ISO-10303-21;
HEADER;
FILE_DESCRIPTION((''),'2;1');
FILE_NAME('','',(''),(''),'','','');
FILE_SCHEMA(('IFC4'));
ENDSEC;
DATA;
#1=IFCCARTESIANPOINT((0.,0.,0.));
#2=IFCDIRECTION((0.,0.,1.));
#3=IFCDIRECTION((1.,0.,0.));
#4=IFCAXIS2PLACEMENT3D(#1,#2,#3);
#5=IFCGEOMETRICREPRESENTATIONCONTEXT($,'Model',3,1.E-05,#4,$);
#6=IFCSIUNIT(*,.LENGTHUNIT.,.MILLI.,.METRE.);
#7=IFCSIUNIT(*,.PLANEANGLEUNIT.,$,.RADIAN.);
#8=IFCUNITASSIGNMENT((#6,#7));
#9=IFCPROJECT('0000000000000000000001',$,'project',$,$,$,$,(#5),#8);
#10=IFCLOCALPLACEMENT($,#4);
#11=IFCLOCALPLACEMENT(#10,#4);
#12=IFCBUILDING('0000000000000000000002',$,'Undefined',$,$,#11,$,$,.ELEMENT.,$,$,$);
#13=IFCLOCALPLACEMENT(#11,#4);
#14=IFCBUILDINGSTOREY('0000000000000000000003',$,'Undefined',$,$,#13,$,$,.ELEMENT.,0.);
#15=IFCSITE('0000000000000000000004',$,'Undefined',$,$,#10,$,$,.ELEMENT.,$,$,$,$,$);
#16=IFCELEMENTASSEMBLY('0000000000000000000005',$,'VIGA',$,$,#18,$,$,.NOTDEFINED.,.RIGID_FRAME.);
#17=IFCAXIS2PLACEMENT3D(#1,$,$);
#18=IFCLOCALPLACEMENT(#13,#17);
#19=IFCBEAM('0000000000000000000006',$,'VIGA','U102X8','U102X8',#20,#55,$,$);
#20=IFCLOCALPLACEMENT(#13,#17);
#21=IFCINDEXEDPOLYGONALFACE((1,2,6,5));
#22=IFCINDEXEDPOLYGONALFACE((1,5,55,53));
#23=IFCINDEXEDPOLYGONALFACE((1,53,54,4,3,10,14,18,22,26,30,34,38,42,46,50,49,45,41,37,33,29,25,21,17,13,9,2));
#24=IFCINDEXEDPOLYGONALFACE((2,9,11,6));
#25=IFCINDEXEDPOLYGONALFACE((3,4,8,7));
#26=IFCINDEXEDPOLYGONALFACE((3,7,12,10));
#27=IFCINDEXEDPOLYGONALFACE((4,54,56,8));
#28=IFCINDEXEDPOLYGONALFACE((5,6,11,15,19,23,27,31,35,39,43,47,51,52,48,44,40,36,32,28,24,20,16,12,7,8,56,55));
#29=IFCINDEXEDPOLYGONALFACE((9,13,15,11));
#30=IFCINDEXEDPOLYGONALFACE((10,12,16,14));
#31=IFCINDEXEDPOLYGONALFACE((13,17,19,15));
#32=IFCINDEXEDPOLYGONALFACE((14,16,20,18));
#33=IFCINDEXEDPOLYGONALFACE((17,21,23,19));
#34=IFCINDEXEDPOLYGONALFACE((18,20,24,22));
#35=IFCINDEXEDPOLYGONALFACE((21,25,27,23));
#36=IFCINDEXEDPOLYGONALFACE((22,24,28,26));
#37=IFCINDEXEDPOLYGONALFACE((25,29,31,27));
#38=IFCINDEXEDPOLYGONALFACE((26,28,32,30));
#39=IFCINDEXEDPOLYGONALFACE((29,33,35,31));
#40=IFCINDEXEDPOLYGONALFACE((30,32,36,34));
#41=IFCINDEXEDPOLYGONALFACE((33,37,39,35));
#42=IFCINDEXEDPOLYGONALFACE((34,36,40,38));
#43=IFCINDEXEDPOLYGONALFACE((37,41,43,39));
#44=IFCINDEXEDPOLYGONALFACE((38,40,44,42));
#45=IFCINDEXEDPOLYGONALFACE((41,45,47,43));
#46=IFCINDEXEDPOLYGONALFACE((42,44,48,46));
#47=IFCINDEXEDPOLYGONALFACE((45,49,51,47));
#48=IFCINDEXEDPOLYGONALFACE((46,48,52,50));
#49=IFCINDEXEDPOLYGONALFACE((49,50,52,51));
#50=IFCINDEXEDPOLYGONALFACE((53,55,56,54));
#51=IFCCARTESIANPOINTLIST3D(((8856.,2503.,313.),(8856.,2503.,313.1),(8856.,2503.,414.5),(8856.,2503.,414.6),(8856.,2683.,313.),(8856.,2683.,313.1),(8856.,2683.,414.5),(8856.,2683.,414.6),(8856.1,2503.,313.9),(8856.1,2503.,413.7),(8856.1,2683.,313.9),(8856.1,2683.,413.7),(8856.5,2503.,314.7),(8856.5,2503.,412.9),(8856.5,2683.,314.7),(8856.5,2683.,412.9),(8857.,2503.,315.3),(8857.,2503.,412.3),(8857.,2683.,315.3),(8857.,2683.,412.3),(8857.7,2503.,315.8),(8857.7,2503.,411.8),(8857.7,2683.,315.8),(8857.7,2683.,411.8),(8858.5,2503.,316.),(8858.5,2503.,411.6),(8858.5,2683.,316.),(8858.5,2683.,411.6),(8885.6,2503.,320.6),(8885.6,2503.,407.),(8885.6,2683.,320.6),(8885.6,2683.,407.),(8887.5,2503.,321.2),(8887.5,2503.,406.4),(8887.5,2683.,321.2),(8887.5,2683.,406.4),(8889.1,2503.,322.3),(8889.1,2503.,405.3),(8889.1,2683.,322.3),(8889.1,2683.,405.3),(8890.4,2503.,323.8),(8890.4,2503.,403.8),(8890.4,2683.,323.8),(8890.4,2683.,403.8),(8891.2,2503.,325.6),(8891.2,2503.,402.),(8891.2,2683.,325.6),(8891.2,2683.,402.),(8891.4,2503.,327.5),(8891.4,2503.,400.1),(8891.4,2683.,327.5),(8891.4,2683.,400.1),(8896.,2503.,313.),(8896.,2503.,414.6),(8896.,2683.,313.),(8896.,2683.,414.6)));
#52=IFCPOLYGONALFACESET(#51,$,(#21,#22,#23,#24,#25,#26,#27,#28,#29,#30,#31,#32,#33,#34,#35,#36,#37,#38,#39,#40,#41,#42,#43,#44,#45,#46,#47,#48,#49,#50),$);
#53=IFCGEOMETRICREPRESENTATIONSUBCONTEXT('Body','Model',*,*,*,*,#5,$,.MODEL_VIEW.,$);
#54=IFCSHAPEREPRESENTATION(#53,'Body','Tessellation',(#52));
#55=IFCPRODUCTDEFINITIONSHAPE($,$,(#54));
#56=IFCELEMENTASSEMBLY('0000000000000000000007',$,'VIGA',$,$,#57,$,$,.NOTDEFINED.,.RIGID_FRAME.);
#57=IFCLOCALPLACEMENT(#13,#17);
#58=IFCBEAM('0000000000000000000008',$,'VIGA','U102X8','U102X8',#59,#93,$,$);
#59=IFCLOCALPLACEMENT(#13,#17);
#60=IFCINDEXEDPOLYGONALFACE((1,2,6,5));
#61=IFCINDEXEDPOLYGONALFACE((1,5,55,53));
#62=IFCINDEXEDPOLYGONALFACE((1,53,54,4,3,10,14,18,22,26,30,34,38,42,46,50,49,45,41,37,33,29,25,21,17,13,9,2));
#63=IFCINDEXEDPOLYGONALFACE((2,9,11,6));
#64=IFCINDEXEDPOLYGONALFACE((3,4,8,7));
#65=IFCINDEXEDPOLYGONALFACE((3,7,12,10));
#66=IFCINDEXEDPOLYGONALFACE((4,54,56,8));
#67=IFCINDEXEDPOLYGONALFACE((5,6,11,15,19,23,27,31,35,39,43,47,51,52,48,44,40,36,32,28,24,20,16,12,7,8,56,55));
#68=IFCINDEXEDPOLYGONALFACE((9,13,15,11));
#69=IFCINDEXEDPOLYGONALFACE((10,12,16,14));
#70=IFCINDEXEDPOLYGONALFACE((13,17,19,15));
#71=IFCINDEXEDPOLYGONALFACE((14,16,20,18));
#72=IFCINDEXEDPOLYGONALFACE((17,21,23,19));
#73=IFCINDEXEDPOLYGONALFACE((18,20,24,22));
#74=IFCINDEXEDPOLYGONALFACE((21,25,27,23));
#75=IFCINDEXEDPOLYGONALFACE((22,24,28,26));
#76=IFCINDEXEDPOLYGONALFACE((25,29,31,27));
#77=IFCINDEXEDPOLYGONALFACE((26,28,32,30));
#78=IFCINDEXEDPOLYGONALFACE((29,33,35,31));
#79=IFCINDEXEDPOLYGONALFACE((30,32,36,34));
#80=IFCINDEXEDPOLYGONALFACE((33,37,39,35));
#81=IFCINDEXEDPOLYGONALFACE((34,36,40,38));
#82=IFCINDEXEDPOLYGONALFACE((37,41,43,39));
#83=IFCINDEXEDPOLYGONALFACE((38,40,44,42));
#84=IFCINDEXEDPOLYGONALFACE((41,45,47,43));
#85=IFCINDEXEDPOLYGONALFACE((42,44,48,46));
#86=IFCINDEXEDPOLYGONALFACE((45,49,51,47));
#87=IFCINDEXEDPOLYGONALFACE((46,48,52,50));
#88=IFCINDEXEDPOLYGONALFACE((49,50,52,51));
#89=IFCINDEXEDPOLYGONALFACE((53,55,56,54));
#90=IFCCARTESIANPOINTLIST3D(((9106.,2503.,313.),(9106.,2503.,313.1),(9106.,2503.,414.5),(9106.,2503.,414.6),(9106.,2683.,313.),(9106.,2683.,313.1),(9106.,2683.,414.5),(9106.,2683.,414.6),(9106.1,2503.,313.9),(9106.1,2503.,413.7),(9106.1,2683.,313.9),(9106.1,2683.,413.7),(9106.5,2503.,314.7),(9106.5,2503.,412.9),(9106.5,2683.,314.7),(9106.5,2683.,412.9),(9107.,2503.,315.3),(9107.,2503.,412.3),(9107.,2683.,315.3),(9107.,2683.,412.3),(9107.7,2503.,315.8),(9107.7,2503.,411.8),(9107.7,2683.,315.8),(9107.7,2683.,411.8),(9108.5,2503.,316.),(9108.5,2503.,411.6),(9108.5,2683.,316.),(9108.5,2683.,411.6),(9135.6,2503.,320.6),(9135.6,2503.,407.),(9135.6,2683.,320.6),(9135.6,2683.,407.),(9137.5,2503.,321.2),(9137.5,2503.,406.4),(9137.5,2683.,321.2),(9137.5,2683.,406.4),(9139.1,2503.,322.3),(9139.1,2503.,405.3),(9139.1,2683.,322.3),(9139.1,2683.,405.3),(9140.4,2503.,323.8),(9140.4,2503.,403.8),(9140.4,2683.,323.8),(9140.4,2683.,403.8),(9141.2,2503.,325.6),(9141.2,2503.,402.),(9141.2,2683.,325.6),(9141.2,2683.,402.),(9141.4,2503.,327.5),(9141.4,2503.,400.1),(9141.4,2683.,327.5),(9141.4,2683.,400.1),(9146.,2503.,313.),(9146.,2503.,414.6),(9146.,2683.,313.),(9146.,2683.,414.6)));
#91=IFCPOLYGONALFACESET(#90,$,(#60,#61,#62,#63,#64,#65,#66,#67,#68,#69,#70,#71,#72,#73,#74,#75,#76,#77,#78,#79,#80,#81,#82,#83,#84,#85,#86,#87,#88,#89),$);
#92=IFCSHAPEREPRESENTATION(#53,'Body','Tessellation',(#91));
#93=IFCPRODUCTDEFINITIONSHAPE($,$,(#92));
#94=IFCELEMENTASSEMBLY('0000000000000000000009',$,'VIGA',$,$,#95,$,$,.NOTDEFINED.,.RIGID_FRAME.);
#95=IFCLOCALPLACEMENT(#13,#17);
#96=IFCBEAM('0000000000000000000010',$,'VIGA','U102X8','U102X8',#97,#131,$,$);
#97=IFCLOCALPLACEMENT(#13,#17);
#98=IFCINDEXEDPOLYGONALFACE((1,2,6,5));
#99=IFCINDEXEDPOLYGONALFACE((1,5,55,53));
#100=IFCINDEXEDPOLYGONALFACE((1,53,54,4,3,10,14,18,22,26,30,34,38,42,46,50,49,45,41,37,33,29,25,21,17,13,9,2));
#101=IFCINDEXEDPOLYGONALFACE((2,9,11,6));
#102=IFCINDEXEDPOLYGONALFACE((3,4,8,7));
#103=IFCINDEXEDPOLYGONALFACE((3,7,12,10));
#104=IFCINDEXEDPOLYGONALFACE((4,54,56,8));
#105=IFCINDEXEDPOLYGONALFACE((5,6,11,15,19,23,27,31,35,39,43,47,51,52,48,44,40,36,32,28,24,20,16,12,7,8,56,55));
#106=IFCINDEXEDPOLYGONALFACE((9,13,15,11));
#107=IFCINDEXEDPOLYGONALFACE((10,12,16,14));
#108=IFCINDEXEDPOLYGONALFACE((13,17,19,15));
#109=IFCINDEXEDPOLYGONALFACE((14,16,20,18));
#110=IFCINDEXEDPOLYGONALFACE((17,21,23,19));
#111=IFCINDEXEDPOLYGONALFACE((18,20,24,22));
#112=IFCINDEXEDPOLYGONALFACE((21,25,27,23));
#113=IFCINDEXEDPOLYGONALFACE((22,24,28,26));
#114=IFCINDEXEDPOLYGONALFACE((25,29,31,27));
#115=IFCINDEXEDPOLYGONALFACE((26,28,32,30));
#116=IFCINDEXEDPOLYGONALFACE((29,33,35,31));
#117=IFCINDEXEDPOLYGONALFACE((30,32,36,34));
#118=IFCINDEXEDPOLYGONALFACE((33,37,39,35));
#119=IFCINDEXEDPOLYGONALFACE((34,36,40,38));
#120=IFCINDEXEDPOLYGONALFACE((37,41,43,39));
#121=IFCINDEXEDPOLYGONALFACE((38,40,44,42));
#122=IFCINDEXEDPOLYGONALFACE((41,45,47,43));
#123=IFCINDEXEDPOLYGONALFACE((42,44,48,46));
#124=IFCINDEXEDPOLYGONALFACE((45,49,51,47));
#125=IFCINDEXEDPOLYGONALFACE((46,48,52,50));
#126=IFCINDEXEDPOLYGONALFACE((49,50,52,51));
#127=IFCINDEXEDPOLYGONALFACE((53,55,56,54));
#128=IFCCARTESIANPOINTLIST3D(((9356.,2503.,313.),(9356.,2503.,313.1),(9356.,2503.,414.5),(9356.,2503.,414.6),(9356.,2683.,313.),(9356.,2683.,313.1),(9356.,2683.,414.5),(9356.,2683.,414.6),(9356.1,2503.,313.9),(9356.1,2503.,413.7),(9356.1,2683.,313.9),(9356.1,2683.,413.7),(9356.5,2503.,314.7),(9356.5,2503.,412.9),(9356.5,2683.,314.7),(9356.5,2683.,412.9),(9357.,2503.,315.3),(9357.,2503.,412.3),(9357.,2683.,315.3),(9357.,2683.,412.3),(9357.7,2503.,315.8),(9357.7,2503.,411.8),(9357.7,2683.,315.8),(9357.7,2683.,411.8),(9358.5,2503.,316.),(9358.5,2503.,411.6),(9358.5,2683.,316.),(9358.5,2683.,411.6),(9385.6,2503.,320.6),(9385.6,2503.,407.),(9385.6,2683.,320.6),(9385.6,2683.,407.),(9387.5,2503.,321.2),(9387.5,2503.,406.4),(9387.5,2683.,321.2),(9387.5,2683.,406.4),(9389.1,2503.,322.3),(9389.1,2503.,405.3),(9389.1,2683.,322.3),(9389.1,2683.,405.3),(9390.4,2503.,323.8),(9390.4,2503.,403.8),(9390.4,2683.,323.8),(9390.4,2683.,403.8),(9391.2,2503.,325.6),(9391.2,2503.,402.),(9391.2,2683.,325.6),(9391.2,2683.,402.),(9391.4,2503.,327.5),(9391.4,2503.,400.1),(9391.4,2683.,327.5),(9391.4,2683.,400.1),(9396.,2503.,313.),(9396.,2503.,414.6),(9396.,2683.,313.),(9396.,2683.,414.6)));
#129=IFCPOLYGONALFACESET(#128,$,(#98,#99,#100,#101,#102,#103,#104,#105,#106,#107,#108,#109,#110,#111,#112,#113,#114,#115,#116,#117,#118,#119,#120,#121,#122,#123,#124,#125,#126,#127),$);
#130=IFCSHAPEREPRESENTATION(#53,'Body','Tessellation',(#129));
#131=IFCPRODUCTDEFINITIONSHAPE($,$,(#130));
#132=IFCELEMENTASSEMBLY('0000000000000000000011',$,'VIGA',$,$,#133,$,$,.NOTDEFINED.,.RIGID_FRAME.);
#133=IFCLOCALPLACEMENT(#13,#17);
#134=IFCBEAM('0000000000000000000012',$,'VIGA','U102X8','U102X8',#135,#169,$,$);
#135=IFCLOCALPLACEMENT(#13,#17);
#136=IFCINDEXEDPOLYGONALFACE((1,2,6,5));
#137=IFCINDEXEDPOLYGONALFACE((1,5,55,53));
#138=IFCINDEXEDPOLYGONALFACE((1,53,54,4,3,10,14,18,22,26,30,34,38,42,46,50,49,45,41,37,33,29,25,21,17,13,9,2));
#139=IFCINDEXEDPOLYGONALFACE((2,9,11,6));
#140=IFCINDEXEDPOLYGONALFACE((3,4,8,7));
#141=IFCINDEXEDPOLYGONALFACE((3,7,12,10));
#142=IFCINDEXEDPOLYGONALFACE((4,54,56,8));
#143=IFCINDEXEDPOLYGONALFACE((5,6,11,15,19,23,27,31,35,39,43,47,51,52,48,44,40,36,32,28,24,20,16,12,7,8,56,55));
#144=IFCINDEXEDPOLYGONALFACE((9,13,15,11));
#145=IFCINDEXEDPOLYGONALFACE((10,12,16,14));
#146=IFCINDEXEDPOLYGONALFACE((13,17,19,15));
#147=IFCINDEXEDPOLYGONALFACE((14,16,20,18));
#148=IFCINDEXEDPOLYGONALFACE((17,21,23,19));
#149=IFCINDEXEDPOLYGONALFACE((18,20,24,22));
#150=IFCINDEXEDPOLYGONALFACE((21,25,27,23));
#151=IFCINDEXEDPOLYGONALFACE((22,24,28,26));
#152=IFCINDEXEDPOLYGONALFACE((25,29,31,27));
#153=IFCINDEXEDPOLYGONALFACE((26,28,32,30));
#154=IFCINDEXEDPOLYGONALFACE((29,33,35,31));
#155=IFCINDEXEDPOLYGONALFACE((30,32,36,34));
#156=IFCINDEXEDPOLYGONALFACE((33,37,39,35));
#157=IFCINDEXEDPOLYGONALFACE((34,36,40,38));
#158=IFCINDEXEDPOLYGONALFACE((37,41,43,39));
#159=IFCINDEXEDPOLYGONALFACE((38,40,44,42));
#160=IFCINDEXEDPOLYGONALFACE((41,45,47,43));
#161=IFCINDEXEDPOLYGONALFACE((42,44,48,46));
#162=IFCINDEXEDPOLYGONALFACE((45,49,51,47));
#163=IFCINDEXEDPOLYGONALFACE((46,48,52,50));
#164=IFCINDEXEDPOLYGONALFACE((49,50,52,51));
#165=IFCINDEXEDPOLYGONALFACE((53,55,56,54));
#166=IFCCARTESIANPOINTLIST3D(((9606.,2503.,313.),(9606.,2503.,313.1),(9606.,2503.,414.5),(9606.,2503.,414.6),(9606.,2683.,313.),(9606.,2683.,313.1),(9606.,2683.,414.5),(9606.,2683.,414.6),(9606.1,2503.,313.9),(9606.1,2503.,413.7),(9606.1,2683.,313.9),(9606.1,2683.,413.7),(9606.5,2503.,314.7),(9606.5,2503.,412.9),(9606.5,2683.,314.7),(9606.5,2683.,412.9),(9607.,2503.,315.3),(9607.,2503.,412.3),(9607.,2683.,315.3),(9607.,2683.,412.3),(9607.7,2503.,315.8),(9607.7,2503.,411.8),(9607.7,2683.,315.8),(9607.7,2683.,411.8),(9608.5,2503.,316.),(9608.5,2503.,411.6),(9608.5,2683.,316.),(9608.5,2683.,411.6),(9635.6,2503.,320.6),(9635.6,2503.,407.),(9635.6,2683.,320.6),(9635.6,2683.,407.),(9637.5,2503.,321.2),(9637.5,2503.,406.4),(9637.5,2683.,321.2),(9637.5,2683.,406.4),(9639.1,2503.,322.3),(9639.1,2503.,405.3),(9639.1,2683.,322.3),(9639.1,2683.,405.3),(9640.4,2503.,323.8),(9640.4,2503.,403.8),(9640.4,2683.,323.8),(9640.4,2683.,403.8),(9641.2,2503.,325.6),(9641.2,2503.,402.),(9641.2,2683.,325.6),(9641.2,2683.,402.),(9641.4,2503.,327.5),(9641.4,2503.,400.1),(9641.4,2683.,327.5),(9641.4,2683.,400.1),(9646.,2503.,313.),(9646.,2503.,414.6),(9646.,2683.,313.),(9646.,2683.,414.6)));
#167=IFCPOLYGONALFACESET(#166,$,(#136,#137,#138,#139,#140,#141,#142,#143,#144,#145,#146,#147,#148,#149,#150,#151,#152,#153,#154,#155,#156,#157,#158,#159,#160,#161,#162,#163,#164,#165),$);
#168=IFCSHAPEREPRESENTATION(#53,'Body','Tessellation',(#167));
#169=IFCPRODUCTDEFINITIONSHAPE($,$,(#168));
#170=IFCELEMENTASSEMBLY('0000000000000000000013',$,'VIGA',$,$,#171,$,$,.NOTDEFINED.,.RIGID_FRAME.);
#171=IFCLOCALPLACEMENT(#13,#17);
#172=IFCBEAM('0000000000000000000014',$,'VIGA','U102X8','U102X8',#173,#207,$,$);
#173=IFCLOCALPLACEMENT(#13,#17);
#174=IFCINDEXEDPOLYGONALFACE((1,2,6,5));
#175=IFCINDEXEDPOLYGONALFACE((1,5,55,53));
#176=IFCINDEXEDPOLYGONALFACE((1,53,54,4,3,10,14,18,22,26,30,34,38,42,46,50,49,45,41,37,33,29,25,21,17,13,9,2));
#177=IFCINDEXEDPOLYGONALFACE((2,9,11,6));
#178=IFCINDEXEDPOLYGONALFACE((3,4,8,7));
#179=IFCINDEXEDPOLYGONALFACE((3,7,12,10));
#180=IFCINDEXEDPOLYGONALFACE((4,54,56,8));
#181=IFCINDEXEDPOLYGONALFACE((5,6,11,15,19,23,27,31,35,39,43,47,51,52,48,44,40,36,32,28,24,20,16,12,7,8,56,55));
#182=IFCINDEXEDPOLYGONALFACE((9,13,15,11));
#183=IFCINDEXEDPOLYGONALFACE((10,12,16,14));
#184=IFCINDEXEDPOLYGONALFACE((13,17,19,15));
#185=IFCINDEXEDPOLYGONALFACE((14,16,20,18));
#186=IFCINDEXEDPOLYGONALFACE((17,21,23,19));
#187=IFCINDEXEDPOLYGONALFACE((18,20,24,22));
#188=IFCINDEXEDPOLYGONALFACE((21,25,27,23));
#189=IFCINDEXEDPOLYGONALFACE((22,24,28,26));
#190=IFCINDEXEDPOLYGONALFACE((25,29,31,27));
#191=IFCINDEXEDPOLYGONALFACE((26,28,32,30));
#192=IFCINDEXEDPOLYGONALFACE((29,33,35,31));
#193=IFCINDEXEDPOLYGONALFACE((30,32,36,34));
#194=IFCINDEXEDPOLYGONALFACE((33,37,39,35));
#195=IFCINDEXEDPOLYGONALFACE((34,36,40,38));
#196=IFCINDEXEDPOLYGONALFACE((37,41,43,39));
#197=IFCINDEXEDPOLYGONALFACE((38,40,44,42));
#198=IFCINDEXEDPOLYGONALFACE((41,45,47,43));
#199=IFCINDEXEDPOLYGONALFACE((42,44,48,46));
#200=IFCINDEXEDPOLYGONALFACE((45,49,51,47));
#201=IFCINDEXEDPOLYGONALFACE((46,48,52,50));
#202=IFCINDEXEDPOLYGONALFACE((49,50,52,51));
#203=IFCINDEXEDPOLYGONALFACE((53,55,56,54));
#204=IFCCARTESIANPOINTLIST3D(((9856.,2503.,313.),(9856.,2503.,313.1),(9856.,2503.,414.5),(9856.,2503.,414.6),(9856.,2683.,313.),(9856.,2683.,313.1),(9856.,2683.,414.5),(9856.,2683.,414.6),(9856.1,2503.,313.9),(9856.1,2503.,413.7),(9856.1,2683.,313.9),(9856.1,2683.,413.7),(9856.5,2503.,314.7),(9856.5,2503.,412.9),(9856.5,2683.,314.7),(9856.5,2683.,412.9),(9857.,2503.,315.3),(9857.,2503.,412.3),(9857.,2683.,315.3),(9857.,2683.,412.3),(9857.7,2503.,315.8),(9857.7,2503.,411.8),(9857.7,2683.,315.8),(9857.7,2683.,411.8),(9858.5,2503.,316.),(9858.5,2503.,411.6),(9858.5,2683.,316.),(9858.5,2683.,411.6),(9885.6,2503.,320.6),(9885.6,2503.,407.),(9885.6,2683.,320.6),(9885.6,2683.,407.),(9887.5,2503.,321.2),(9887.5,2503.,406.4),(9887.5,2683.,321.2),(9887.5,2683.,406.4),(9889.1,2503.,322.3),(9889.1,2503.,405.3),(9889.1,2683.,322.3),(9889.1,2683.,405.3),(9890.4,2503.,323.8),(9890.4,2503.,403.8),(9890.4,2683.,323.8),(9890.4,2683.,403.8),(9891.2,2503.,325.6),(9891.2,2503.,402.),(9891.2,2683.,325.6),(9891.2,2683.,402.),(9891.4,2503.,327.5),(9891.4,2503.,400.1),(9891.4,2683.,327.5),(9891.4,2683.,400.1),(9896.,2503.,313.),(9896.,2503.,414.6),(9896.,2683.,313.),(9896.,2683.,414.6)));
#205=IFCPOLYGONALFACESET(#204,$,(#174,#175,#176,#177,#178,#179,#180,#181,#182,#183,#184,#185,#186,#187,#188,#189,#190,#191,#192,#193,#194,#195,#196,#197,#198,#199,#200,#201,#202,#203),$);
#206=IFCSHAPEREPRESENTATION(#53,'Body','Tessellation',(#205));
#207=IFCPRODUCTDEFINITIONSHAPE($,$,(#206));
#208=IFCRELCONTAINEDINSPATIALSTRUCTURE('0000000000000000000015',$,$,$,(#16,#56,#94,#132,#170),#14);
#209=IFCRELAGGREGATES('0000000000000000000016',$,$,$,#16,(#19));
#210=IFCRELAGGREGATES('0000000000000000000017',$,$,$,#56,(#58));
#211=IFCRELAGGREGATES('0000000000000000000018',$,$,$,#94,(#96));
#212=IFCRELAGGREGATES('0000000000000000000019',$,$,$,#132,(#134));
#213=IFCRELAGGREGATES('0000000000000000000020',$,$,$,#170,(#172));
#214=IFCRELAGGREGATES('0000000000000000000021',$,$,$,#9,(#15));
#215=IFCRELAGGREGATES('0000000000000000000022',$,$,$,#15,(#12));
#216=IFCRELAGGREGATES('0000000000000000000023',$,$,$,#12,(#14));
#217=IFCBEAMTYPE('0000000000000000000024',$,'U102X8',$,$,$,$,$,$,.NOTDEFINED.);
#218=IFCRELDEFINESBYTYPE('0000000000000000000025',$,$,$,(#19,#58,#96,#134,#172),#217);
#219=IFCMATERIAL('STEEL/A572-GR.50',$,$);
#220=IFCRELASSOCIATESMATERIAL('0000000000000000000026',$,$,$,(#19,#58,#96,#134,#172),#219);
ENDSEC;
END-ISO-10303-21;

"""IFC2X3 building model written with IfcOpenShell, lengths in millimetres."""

from ifc_helpers import new_model, si_unit, frame, origin_with_axes, origin_2d_with_axis, place, context, subcontext, project, spatial, u_section, extrude, material, type_object, element, aggregate, save


model = new_model("IFC2X3")

# Units and contexts
model_context = context("Model", 3, precision=1e-05, world=origin_with_axes())
body_context = subcontext(model_context, "Body", "Model", "MODEL_VIEW")
ifc_project = project(units=[si_unit("LENGTHUNIT", "METRE", prefix="MILLI"), si_unit("PLANEANGLEUNIT", "RADIAN")], contexts=[model_context])

# Site, building, storey
site_placement = place(None, origin_with_axes())
site = spatial("IfcSite", under=ifc_project, at=site_placement, Name="Undefined", CompositionType="ELEMENT")
building_placement = place(site_placement, origin_with_axes())
building = spatial("IfcBuilding", under=site, at=building_placement, Name="Undefined", CompositionType="ELEMENT")
storey_placement = place(building_placement, origin_with_axes())
storey = spatial("IfcBuildingStorey", under=building, at=storey_placement, Name="Undefined", CompositionType="ELEMENT", Elevation=0.0)

# Element assemblies, beams
ifc_material_1 = material(Name="STEEL/A572-GR.50")
beam_type = type_object("IfcBeamType", Name="U102X8", PredefinedType="NOTDEFINED")
assembly_1_placement = place(storey_placement, origin_with_axes())
assembly_1 = element("IfcElementAssembly", 1, at=assembly_1_placement, inside=storey, Name="VIGA", AssemblyPlace="NOTDEFINED", PredefinedType="RIGID_FRAME")
beam_1_placement = place(assembly_1_placement, frame((8876.0, 2683.0, 363.8), z_axis=(0.0, 0.0, 1.0), x_axis=(0.0, -1.0, 0.0)))
beam_1 = element("IfcBeam", 2, at=beam_1_placement, type_object=beam_type, material=ifc_material_1, Name="VIGA", Description="U102X8", ObjectType="U102X8", context=body_context, shape_type="SweptSolid", body=[
    extrude(u_section(Depth=101.6, FlangeWidth=40.0, WebThickness=4.6, FlangeThickness=6.0, FilletRadius=7.0, EdgeRadius=3.0, FlangeSlope=0.16839, at=origin_2d_with_axis()), frame((180.0, 0.0, 0.0), z_axis=(-1.0, 0.0, 0.0), x_axis=(0.0, -1.0, 0.0)), (0.0, 0.0, 1.0), 180.0),
])
aggregate(assembly_1, [beam_1])
assembly_2_placement = place(storey_placement, origin_with_axes())
assembly_2 = element("IfcElementAssembly", 3, at=assembly_2_placement, inside=storey, Name="VIGA", AssemblyPlace="NOTDEFINED", PredefinedType="RIGID_FRAME")
beam_2_placement = place(assembly_2_placement, frame((9126.0, 2683.0, 363.8), z_axis=(0.0, 0.0, 1.0), x_axis=(0.0, -1.0, 0.0)))
beam_2 = element("IfcBeam", 4, at=beam_2_placement, type_object=beam_type, material=ifc_material_1, Name="VIGA", Description="U102X8", ObjectType="U102X8", context=body_context, shape_type="SweptSolid", body=[
    extrude(u_section(Depth=101.6, FlangeWidth=40.0, WebThickness=4.6, FlangeThickness=6.0, FilletRadius=7.0, EdgeRadius=3.0, FlangeSlope=0.16839, at=origin_2d_with_axis()), frame((180.0, 0.0, 0.0), z_axis=(-1.0, 0.0, 0.0), x_axis=(0.0, -1.0, 0.0)), (0.0, 0.0, 1.0), 180.0),
])
aggregate(assembly_2, [beam_2])
assembly_3_placement = place(storey_placement, origin_with_axes())
assembly_3 = element("IfcElementAssembly", 5, at=assembly_3_placement, inside=storey, Name="VIGA", AssemblyPlace="NOTDEFINED", PredefinedType="RIGID_FRAME")
beam_3_placement = place(assembly_3_placement, frame((9376.0, 2683.0, 363.8), z_axis=(0.0, 0.0, 1.0), x_axis=(0.0, -1.0, 0.0)))
beam_3 = element("IfcBeam", 6, at=beam_3_placement, type_object=beam_type, material=ifc_material_1, Name="VIGA", Description="U102X8", ObjectType="U102X8", context=body_context, shape_type="SweptSolid", body=[
    extrude(u_section(Depth=101.6, FlangeWidth=40.0, WebThickness=4.6, FlangeThickness=6.0, FilletRadius=7.0, EdgeRadius=3.0, FlangeSlope=0.16839, at=origin_2d_with_axis()), frame((180.0, 0.0, 0.0), z_axis=(-1.0, 0.0, 0.0), x_axis=(0.0, -1.0, 0.0)), (0.0, 0.0, 1.0), 180.0),
])
aggregate(assembly_3, [beam_3])
assembly_4_placement = place(storey_placement, origin_with_axes())
assembly_4 = element("IfcElementAssembly", 7, at=assembly_4_placement, inside=storey, Name="VIGA", AssemblyPlace="NOTDEFINED", PredefinedType="RIGID_FRAME")
beam_4_placement = place(assembly_4_placement, frame((9626.0, 2683.0, 363.8), z_axis=(0.0, 0.0, 1.0), x_axis=(0.0, -1.0, 0.0)))
beam_4 = element("IfcBeam", 8, at=beam_4_placement, type_object=beam_type, material=ifc_material_1, Name="VIGA", Description="U102X8", ObjectType="U102X8", context=body_context, shape_type="SweptSolid", body=[
    extrude(u_section(Depth=101.6, FlangeWidth=40.0, WebThickness=4.6, FlangeThickness=6.0, FilletRadius=7.0, EdgeRadius=3.0, FlangeSlope=0.16839, at=origin_2d_with_axis()), frame((180.0, 0.0, 0.0), z_axis=(-1.0, 0.0, 0.0), x_axis=(0.0, -1.0, 0.0)), (0.0, 0.0, 1.0), 180.0),
])
aggregate(assembly_4, [beam_4])
assembly_5_placement = place(storey_placement, origin_with_axes())
assembly_5 = element("IfcElementAssembly", 9, at=assembly_5_placement, inside=storey, Name="VIGA", AssemblyPlace="NOTDEFINED", PredefinedType="RIGID_FRAME")
beam_5_placement = place(assembly_5_placement, frame((9876.0, 2683.0, 363.8), z_axis=(0.0, 0.0, 1.0), x_axis=(0.0, -1.0, 0.0)))
beam_5 = element("IfcBeam", 10, at=beam_5_placement, type_object=beam_type, material=ifc_material_1, Name="VIGA", Description="U102X8", ObjectType="U102X8", context=body_context, shape_type="SweptSolid", body=[
    extrude(u_section(Depth=101.6, FlangeWidth=40.0, WebThickness=4.6, FlangeThickness=6.0, FilletRadius=7.0, EdgeRadius=3.0, FlangeSlope=0.16839, at=origin_2d_with_axis()), frame((180.0, 0.0, 0.0), z_axis=(-1.0, 0.0, 0.0), x_axis=(0.0, -1.0, 0.0)), (0.0, 0.0, 1.0), 180.0),
])
aggregate(assembly_5, [beam_5])

save(model, "model.ifc")
